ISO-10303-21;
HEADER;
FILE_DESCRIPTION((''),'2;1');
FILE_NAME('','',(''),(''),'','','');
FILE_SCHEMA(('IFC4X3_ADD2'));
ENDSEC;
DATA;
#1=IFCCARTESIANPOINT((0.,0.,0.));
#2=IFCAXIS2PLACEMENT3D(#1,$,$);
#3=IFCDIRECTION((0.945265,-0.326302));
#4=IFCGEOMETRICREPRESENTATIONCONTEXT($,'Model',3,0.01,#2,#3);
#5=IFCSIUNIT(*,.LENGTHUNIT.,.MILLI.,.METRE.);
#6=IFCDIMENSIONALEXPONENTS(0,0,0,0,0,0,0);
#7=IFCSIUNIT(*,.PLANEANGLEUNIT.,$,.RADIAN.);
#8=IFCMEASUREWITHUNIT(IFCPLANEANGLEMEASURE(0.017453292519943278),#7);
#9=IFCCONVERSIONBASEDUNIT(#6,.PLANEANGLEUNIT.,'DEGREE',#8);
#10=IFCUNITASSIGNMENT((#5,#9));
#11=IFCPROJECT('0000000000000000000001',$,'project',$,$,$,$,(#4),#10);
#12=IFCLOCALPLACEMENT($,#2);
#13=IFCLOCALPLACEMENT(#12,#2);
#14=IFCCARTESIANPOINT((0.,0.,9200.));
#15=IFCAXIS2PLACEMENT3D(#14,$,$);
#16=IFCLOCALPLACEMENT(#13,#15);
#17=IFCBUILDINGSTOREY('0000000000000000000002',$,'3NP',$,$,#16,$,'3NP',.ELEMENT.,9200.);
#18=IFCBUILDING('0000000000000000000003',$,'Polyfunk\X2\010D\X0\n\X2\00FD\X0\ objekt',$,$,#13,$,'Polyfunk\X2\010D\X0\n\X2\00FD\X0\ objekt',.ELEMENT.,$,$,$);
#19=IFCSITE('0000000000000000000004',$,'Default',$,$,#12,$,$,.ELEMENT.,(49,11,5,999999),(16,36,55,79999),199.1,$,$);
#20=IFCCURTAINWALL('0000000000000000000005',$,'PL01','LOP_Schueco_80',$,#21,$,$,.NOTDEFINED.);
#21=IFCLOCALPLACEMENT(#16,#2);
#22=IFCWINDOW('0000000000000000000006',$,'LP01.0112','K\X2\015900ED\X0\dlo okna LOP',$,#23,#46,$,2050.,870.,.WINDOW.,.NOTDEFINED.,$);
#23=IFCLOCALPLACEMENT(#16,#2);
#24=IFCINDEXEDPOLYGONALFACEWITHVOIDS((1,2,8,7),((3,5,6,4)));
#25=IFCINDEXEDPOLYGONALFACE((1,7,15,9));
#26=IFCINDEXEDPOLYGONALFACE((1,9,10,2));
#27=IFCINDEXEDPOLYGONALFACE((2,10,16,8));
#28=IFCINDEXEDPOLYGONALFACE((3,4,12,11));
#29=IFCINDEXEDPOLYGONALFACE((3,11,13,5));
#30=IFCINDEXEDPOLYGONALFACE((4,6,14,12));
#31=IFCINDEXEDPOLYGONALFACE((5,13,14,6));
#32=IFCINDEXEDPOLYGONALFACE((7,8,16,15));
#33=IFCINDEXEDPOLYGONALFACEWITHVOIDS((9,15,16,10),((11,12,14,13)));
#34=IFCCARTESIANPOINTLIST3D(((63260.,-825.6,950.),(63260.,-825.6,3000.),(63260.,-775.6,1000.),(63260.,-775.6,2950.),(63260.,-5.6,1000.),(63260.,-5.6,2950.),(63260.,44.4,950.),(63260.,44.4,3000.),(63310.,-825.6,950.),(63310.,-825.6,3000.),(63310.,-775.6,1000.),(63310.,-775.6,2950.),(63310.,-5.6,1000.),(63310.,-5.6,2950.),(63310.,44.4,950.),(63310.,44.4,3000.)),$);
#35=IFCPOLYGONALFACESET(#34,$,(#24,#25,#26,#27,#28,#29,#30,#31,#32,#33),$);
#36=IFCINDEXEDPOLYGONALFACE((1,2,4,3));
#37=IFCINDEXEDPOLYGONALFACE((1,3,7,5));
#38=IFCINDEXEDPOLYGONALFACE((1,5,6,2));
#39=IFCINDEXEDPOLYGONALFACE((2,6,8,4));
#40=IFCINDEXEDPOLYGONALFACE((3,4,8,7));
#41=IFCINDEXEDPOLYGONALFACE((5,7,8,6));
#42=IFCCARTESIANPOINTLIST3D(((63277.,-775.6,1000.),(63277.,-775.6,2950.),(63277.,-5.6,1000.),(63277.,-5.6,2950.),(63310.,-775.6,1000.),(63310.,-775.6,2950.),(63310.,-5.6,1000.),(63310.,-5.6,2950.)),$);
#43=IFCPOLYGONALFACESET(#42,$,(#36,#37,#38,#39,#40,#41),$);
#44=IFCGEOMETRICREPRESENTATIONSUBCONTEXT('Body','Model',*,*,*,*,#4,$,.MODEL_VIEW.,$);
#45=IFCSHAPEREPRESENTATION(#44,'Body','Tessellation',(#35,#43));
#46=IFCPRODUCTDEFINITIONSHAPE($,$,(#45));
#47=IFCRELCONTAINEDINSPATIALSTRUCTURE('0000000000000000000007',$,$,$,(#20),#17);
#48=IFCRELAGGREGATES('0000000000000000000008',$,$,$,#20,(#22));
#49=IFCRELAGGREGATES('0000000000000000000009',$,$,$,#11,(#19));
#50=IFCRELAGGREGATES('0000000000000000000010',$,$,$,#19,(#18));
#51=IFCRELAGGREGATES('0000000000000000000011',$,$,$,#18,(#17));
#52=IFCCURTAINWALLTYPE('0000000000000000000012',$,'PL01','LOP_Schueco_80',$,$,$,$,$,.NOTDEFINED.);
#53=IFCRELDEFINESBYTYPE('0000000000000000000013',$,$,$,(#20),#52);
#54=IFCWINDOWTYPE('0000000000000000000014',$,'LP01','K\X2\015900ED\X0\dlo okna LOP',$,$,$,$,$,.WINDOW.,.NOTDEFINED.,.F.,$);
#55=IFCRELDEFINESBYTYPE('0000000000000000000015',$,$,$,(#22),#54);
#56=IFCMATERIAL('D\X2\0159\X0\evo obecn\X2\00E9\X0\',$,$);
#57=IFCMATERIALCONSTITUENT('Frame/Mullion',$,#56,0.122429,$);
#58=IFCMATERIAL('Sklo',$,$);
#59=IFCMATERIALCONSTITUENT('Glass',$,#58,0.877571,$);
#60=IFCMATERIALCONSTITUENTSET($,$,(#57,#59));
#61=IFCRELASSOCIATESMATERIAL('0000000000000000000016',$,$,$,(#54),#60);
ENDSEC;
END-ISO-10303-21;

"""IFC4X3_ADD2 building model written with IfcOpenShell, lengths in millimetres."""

from ifc_helpers import new_model, entity, si_unit, converted_unit, direction, frame, origin, origin_2d_with_axis, place, context, subcontext, project, spatial, polyline, rectangle, outline, extrude, source, transform, mapped, material, constituent, constituent_set, type_object, type_shapes, element, aggregate, save


model = new_model("IFC4X3_ADD2")

# Units and contexts
model_context = context("Model", 3, precision=0.01, world=origin(), true_north=direction((0.945265, -0.326302)))
body_context = subcontext(model_context, "Body", "Model", "MODEL_VIEW")
ifc_project = project(units=[si_unit("LENGTHUNIT", "METRE", prefix="MILLI"), converted_unit("PLANEANGLEUNIT", "DEGREE", entity("IfcPlaneAngleMeasure", 0.017453292519943278), si_unit("PLANEANGLEUNIT", "RADIAN"), dimensions=[0, 0, 0, 0, 0, 0, 0])], contexts=[model_context])

# Site, building, storey
site_placement = place(None, origin())
site = spatial("IfcSite", under=ifc_project, at=site_placement, Name="Default", CompositionType="ELEMENT", RefLatitude=(49, 11, 5, 999999), RefLongitude=(16, 36, 55, 79999), RefElevation=199.1)
building_placement = place(site_placement, origin())
building = spatial("IfcBuilding", under=site, at=building_placement, Name="Polyfunkčný objekt", LongName="Polyfunkčný objekt", CompositionType="ELEMENT")
storey_placement = place(building_placement, frame((0.0, 0.0, 9200.0)))
storey = spatial("IfcBuildingStorey", under=building, at=storey_placement, Name="3NP", LongName="3NP", CompositionType="ELEMENT", Elevation=9200.0)

# Curtain wall, window
curtain_wall_type = type_object("IfcCurtainWallType", Name="PL01", Description="LOP_Schueco_80", PredefinedType="NOTDEFINED")
curtain_wall_placement = place(storey_placement, frame((0.0, 0.0, -9200.0)))
curtain_wall = element("IfcCurtainWall", 1, at=curtain_wall_placement, inside=storey, type_object=curtain_wall_type, Name="PL01", Description="LOP_Schueco_80", PredefinedType="NOTDEFINED")
ifc_material_1 = material(Name="Sklo")
ifc_material_2 = material(Name="Dřevo obecné")
ifc_constituent_1 = constituent(ifc_material_2, Name="Frame/Mullion", fraction=0.122429)
ifc_constituent_2 = constituent(ifc_material_1, Name="Glass", fraction=0.877571)
ifc_constituent_set = constituent_set(constituents=[ifc_constituent_1, ifc_constituent_2])
window_type = type_object("IfcWindowType", Name="LP01", Description="Křídlo okna LOP", ParameterTakesPrecedence=False, PartitioningType="NOTDEFINED", PredefinedType="WINDOW", material=ifc_constituent_set)
shared_shape_1 = source(origin(), body_context, "Body", "SweptSolid", [
    extrude(outline(polyline([(-1025.0, -435.0), (1025.0, -435.0), (1025.0, 435.0), (-1025.0, 435.0), (-1025.0, -435.0)]), holes=[polyline([(-975.0, -385.0), (-975.0, 385.0), (975.0, 385.0), (975.0, -385.0), (-975.0, -385.0)])]), frame((0.0, 0.0, 1025.0), z_axis=(0.0, 1.0, 0.0), x_axis=(0.0, 0.0, -1.0)), (0.0, 0.0, 1.0), 50.0),
    extrude(rectangle(XDim=33.0, YDim=770.0, at=origin_2d_with_axis()), frame((0.0, 33.5, 50.0), z_axis=(0.0, 0.0, 1.0), x_axis=(0.0, -1.0, 0.0)), (0.0, 0.0, 1.0), 1950.0),
])
type_shapes(window_type, [shared_shape_1])
window_placement = place(curtain_wall_placement, frame((63260.0, -390.6, 10150.0), z_axis=(0.0, 0.0, 1.0), x_axis=(0.0, -1.0, 0.0)))
window = element("IfcWindow", 2, at=window_placement, type_object=window_type, Name="LP01.0112", Description="Křídlo okna LOP", OverallHeight=2050.0, OverallWidth=870.0, PartitioningType="NOTDEFINED", PredefinedType="WINDOW", context=body_context, shape_type="MappedRepresentation", body=[
    mapped(shared_shape_1, transform((0.0, 0.0, 0.0), scale=1.0)),
])
aggregate(curtain_wall, [window])

save(model, "model.ifc")
